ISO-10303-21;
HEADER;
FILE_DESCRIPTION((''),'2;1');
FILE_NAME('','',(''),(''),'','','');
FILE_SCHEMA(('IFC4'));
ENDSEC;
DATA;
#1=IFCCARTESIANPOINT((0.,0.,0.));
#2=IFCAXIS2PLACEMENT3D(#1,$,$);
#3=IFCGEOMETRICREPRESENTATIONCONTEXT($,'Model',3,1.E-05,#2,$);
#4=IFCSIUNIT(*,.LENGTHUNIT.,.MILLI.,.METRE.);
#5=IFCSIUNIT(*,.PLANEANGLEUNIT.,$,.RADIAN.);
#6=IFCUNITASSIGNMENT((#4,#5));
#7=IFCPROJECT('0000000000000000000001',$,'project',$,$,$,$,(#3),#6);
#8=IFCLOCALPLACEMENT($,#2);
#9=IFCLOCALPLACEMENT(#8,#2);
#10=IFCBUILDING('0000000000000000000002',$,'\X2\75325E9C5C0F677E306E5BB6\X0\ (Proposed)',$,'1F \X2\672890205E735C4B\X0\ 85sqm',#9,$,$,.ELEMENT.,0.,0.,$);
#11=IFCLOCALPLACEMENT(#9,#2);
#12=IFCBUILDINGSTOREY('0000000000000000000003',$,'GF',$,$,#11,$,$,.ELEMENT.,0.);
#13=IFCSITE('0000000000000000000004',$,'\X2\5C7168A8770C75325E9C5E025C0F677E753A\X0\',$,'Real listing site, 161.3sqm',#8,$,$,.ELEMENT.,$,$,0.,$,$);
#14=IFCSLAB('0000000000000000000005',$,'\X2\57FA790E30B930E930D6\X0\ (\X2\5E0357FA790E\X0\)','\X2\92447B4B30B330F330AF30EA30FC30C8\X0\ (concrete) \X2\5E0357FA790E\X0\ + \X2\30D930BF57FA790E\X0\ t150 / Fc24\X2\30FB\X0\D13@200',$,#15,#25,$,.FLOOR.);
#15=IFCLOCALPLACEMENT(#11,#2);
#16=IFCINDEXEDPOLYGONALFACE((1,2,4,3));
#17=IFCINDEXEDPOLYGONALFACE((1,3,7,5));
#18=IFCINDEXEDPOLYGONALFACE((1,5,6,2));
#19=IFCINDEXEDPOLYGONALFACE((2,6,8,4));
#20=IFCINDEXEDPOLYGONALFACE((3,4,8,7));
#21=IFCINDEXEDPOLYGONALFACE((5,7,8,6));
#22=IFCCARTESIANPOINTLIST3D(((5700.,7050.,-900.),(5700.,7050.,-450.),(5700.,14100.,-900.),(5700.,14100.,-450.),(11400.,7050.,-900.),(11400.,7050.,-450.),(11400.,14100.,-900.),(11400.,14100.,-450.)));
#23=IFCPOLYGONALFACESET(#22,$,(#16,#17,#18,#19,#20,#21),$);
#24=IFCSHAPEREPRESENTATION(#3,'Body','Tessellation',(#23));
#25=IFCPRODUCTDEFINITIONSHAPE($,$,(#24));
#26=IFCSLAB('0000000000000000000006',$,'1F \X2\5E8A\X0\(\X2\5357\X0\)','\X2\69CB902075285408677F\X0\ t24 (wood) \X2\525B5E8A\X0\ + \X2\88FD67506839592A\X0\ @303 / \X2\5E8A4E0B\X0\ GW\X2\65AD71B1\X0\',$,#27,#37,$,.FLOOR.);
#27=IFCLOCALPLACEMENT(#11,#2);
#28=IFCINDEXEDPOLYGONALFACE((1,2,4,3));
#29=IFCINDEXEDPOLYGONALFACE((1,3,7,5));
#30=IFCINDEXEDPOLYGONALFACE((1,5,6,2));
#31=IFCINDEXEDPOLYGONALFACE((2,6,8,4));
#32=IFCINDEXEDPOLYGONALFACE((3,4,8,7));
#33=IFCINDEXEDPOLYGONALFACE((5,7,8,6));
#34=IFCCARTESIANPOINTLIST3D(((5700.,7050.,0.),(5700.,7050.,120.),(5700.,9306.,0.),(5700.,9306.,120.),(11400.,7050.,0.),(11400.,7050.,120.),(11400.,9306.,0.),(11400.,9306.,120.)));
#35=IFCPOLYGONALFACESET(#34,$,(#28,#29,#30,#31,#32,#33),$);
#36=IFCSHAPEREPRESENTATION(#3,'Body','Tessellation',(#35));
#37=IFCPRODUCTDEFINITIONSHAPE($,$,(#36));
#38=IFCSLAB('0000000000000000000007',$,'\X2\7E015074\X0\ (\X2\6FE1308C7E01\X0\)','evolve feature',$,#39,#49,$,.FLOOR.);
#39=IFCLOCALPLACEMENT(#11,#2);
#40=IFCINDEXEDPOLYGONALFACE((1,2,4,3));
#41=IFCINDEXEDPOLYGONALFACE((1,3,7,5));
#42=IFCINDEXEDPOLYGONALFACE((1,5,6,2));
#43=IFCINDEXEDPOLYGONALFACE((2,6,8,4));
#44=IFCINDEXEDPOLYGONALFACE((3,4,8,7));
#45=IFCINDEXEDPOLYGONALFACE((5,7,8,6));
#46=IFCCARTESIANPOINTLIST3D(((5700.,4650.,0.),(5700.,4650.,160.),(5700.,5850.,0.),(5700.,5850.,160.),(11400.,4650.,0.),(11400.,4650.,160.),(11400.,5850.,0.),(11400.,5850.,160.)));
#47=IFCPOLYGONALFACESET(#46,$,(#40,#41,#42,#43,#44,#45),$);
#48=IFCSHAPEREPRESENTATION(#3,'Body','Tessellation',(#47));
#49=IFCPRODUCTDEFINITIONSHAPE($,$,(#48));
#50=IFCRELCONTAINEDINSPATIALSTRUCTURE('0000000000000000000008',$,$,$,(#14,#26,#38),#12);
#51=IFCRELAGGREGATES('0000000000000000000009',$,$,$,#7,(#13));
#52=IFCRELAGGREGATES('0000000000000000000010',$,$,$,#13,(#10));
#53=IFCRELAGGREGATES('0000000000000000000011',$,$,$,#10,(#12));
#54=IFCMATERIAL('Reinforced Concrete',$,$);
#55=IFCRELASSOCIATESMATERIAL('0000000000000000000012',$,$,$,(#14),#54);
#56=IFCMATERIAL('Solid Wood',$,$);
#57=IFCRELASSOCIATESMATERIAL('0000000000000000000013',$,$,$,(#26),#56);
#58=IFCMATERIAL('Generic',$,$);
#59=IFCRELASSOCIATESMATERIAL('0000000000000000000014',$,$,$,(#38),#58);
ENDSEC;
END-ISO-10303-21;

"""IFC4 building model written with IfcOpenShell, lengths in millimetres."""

from ifc_helpers import new_model, si_unit, frame, frame_2d, origin, place, context, project, spatial, rectangle, extrude, material, element, save


model = new_model("IFC4")

# Units and contexts
model_context = context("Model", 3, precision=1e-05, world=origin())
ifc_project = project(units=[si_unit("LENGTHUNIT", "METRE", prefix="MILLI"), si_unit("PLANEANGLEUNIT", "RADIAN")], contexts=[model_context])

# Site, building, storey
site_placement = place(None, origin())
site = spatial("IfcSite", under=ifc_project, at=site_placement, Name="山梨県甲府市小松町", ObjectType="Real listing site, 161.3sqm", CompositionType="ELEMENT", RefElevation=0.0)
building_placement = place(site_placement, origin())
building = spatial("IfcBuilding", under=site, at=building_placement, Name="甲府小松の家 (Proposed)", ObjectType="1F 木造平屋 85sqm", CompositionType="ELEMENT", ElevationOfRefHeight=0.0, ElevationOfTerrain=0.0)
storey_placement = place(building_placement, origin())
storey = spatial("IfcBuildingStorey", under=building, at=storey_placement, Name="GF", CompositionType="ELEMENT", Elevation=0.0)

# Slabs
ifc_material_1 = material(Name="Reinforced Concrete")
slab_1_placement = place(storey_placement, frame((2850.0, 3525.0, -450.0)))
element("IfcSlab", 1, at=slab_1_placement, inside=storey, material=ifc_material_1, Name="基礎スラブ (布基礎)", Description="鉄筋コンクリート (concrete) 布基礎 + ベタ基礎 t150 / Fc24・D13@200", PredefinedType="FLOOR", context=model_context, shape_type="SweptSolid", body=[
    extrude(rectangle(XDim=5700.0, YDim=7050.0, at=frame_2d((2850.0, 3525.0))), frame((2850.0, 3525.0, -450.0)), (0.0, 0.0, 1.0), 450.0),
])
ifc_material_2 = material(Name="Solid Wood")
slab_2_placement = place(storey_placement, frame((2850.0, 3525.0, 0.0)))
element("IfcSlab", 2, at=slab_2_placement, inside=storey, material=ifc_material_2, Name="1F 床(南)", Description="構造用合板 t24 (wood) 剛床 + 製材根太 @303 / 床下 GW断熱", PredefinedType="FLOOR", context=model_context, shape_type="SweptSolid", body=[
    extrude(rectangle(XDim=5700.0, YDim=2256.0, at=frame_2d((2850.0, 1128.0))), frame((2850.0, 3525.0, 0.0)), (0.0, 0.0, 1.0), 120.0),
])
ifc_material_3 = material(Name="Generic")
slab_3_placement = place(storey_placement, frame((2850.0, 2325.0, 0.0)))
element("IfcSlab", 3, at=slab_3_placement, inside=storey, material=ifc_material_3, Name="縁側 (濡れ縁)", Description="evolve feature", PredefinedType="FLOOR", context=model_context, shape_type="SweptSolid", body=[
    extrude(rectangle(XDim=5700.0, YDim=1200.0, at=frame_2d((2850.0, 600.0))), frame((2850.0, 2325.0, 0.0)), (0.0, 0.0, 1.0), 160.0),
])

save(model, "model.ifc")
